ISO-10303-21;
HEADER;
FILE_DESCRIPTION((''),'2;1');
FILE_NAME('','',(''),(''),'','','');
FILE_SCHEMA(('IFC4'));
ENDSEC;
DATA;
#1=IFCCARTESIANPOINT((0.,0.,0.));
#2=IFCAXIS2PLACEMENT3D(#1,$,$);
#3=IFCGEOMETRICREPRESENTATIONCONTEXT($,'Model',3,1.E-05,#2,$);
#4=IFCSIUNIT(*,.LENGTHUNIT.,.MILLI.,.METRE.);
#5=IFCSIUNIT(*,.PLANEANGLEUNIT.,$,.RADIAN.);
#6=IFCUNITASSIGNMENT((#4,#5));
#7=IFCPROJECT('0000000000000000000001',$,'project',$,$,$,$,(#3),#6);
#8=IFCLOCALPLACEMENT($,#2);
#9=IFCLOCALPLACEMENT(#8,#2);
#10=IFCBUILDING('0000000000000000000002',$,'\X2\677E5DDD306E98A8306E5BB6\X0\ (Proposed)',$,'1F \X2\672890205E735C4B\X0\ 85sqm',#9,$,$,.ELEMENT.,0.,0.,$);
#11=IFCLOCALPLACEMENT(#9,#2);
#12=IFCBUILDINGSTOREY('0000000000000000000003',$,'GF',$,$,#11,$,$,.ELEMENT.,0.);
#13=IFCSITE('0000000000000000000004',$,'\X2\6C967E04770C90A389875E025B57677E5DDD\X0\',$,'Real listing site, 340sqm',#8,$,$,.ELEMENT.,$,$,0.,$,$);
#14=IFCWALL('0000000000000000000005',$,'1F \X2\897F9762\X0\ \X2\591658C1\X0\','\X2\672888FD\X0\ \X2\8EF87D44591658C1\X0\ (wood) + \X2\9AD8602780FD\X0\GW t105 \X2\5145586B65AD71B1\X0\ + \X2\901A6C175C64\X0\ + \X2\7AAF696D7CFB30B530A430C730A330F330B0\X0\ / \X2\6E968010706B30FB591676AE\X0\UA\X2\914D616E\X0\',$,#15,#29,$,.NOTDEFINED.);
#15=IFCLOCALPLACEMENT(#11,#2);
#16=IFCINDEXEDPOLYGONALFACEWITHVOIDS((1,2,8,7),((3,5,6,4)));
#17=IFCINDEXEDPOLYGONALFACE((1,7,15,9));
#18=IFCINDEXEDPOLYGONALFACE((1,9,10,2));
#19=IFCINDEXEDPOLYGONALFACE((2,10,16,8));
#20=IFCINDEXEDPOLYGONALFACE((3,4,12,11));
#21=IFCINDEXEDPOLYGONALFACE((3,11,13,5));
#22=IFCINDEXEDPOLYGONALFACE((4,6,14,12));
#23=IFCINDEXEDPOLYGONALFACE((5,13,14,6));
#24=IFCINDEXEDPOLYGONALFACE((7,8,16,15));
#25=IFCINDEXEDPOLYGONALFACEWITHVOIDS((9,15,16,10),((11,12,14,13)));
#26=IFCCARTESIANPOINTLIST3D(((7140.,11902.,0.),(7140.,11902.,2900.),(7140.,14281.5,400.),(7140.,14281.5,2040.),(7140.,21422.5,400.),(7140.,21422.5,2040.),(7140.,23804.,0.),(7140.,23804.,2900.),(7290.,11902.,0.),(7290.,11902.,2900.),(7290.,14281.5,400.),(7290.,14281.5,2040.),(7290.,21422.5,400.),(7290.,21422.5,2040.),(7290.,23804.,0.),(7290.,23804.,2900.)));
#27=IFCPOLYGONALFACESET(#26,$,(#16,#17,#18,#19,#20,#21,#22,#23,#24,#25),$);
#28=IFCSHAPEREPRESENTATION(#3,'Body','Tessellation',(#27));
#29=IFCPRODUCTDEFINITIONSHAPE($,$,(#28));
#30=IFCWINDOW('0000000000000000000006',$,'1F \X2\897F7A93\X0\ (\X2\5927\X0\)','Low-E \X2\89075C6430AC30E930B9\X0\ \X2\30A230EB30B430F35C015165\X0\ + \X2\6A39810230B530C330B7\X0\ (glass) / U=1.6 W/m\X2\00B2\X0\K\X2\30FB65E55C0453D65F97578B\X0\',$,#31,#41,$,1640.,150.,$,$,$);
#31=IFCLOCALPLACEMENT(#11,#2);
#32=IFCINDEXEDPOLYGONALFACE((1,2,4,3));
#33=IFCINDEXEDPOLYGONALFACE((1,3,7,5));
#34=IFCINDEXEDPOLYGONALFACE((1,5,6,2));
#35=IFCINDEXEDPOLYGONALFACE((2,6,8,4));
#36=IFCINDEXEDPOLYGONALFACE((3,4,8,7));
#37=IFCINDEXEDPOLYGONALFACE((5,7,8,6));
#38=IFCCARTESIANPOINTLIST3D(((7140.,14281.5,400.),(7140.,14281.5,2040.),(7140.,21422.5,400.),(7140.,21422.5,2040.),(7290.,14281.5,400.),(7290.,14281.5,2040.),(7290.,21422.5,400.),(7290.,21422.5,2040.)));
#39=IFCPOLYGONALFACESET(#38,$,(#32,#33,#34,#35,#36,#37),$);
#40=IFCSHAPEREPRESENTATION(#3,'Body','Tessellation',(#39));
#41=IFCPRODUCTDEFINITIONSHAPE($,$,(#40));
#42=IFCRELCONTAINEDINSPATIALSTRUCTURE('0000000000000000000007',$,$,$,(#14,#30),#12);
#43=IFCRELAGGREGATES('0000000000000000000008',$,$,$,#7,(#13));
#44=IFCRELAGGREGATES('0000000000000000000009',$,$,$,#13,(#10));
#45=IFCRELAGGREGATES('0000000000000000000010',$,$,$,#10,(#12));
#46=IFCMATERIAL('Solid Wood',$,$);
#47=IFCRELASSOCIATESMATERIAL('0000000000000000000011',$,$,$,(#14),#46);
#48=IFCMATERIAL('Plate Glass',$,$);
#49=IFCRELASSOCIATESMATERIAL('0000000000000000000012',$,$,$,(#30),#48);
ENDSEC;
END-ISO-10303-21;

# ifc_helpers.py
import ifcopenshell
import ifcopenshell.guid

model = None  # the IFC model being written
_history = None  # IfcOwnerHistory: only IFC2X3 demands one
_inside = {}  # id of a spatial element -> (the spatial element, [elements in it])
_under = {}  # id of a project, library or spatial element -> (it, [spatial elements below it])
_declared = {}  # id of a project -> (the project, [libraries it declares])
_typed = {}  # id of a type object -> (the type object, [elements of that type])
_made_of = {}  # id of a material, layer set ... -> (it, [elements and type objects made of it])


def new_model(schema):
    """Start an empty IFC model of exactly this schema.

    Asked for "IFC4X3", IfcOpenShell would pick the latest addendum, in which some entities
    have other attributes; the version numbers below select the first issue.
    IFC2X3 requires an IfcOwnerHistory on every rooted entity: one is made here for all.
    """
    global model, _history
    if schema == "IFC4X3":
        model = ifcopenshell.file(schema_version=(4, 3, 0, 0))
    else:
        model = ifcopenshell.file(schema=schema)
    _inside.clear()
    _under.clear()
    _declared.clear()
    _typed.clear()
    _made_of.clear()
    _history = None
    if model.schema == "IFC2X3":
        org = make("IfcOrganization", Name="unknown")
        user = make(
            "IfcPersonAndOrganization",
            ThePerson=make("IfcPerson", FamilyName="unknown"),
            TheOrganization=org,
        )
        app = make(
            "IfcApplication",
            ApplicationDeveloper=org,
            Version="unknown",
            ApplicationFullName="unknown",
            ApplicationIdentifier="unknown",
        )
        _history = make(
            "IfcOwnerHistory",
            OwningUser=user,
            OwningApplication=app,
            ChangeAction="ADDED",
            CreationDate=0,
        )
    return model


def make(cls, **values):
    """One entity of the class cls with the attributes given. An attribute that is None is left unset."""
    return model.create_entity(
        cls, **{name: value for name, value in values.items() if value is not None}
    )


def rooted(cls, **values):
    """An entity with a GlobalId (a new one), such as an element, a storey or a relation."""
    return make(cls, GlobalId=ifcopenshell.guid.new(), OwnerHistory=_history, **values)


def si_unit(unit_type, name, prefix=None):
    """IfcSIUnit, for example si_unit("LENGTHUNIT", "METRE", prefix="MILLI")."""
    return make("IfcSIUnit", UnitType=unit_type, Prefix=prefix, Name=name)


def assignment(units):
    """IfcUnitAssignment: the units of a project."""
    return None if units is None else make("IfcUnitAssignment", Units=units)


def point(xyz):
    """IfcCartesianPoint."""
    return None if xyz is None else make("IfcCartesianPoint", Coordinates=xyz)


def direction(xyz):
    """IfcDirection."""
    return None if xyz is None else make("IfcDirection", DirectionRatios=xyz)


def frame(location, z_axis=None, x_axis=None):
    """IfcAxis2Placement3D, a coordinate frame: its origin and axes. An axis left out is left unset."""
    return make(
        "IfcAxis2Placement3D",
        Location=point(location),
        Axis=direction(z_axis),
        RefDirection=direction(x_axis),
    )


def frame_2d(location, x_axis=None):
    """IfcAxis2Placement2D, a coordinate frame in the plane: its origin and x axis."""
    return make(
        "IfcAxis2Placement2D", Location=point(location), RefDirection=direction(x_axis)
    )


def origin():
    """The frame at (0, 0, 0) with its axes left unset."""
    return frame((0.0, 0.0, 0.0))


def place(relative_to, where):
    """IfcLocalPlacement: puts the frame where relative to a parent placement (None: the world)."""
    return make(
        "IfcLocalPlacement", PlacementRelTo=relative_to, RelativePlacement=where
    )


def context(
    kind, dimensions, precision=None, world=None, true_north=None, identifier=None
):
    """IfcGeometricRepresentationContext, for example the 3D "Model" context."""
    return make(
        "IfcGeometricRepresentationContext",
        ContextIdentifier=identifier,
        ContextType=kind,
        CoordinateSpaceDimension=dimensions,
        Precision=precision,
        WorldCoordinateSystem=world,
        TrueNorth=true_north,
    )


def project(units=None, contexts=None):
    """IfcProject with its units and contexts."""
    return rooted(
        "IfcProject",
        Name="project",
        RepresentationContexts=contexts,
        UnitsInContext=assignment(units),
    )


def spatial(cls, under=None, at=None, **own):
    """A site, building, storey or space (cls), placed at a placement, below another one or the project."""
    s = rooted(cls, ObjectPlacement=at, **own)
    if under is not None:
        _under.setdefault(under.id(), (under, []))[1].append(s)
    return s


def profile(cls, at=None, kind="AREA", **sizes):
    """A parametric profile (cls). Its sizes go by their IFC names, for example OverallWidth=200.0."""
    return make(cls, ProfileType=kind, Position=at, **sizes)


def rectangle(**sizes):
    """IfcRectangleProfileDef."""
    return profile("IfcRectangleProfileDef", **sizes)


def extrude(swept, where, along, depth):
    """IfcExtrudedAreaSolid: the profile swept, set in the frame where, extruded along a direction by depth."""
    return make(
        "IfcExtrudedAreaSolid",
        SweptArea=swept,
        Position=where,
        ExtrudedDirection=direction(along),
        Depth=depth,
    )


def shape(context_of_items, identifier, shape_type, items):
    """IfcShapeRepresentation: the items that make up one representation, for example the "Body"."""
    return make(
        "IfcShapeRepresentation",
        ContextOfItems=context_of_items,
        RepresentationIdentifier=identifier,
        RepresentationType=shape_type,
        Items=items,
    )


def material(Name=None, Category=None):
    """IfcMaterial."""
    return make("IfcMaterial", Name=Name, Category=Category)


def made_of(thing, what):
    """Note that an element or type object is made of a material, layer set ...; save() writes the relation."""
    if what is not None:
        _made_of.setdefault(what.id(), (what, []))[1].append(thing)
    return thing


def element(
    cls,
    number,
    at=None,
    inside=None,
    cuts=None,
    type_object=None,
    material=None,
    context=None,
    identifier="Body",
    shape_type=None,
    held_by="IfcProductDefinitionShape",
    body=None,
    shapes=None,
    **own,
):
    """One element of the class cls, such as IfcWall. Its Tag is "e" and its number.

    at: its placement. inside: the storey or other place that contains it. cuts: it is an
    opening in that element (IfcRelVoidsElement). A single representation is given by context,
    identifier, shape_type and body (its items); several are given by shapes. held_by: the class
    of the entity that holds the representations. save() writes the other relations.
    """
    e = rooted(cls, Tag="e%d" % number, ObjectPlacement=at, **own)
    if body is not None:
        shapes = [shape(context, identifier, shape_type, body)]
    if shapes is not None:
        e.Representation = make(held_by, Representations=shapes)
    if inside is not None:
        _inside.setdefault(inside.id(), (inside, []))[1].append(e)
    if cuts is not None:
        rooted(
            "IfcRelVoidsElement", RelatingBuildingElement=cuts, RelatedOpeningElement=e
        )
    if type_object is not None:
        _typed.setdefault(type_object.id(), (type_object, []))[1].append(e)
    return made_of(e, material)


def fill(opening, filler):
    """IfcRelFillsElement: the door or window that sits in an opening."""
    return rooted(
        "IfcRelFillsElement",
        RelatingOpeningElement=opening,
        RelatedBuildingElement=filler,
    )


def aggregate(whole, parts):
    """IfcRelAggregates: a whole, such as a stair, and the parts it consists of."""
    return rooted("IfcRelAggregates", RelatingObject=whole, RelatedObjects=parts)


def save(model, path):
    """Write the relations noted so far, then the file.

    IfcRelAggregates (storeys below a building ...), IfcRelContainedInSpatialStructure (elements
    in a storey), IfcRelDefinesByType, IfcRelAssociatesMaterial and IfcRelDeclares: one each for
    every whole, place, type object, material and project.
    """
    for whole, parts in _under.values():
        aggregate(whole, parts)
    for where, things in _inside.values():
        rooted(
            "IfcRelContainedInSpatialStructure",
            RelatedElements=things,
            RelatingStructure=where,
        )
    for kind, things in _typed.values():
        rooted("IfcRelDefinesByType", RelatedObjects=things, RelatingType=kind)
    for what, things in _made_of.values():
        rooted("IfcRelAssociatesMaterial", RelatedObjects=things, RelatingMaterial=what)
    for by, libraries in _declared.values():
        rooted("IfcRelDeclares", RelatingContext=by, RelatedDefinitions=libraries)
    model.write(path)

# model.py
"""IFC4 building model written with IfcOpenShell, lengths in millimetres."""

from ifc_helpers import new_model, si_unit, frame, frame_2d, origin, place, context, project, spatial, rectangle, extrude, material, element, fill, save


model = new_model("IFC4")

# Units and contexts
model_context = context("Model", 3, precision=1e-05, world=origin())
ifc_project = project(units=[si_unit("LENGTHUNIT", "METRE", prefix="MILLI"), si_unit("PLANEANGLEUNIT", "RADIAN")], contexts=[model_context])

# Site, building, storey
site_placement = place(None, origin())
site = spatial("IfcSite", under=ifc_project, at=site_placement, Name="沖縄県那覇市字松川", ObjectType="Real listing site, 340sqm", CompositionType="ELEMENT", RefElevation=0.0)
building_placement = place(site_placement, origin())
building = spatial("IfcBuilding", under=site, at=building_placement, Name="松川の風の家 (Proposed)", ObjectType="1F 木造平屋 85sqm", CompositionType="ELEMENT", ElevationOfRefHeight=0.0, ElevationOfTerrain=0.0)
storey_placement = place(building_placement, origin())
storey = spatial("IfcBuildingStorey", under=building, at=storey_placement, Name="GF", CompositionType="ELEMENT", Elevation=0.0)

# Shared definitions
ifc_material_1 = material(Name="Solid Wood")

# Shared definitions
ifc_material_2 = material(Name="Plate Glass")

# Wall, opening, window
wall_1_placement = place(storey_placement, frame((3570.0, 5951.0, 0.0)))
wall_1 = element("IfcWall", 1, at=wall_1_placement, inside=storey, material=ifc_material_1, Name="1F 西面 外壁", Description="木製 軸組外壁 (wood) + 高性能GW t105 充填断熱 + 通気層 + 窯業系サイディング / 準耐火・外皮UA配慮", PredefinedType="NOTDEFINED", context=model_context, shape_type="SweptSolid", body=[
    extrude(rectangle(XDim=150.0, YDim=11902.0, at=frame_2d((75.0, 5951.0))), frame((3570.0, 5951.0, 0.0)), (0.0, 0.0, 1.0), 2900.0),
])
opening_1_placement = place(storey_placement, frame((3570.0, 7141.0, 200.0)))
opening_1 = element("IfcOpeningElement", 2, at=opening_1_placement, cuts=wall_1, PredefinedType="NOTDEFINED", context=model_context, shape_type="SweptSolid", body=[
    extrude(rectangle(XDim=150.0, YDim=7141.0, at=frame_2d((75.0, 3570.0))), frame((3570.0, 7141.0, 200.0)), (0.0, 0.0, 1.0), 1640.0),
])
window_1_placement = place(storey_placement, frame((3570.0, 7141.0, 200.0)))
window_1 = element("IfcWindow", 3, at=window_1_placement, inside=storey, material=ifc_material_2, Name="1F 西窓 (大)", Description="Low-E 複層ガラス アルゴン封入 + 樹脂サッシ (glass) / U=1.6 W/m²K・日射取得型", OverallHeight=1640.0, OverallWidth=150.0, context=model_context, shape_type="SweptSolid", body=[
    extrude(rectangle(XDim=150.0, YDim=7141.0, at=frame_2d((75.0, 3570.0))), frame((3570.0, 7141.0, 200.0)), (0.0, 0.0, 1.0), 1640.0),
])
fill(opening_1, window_1)

save(model, "model.ifc")
